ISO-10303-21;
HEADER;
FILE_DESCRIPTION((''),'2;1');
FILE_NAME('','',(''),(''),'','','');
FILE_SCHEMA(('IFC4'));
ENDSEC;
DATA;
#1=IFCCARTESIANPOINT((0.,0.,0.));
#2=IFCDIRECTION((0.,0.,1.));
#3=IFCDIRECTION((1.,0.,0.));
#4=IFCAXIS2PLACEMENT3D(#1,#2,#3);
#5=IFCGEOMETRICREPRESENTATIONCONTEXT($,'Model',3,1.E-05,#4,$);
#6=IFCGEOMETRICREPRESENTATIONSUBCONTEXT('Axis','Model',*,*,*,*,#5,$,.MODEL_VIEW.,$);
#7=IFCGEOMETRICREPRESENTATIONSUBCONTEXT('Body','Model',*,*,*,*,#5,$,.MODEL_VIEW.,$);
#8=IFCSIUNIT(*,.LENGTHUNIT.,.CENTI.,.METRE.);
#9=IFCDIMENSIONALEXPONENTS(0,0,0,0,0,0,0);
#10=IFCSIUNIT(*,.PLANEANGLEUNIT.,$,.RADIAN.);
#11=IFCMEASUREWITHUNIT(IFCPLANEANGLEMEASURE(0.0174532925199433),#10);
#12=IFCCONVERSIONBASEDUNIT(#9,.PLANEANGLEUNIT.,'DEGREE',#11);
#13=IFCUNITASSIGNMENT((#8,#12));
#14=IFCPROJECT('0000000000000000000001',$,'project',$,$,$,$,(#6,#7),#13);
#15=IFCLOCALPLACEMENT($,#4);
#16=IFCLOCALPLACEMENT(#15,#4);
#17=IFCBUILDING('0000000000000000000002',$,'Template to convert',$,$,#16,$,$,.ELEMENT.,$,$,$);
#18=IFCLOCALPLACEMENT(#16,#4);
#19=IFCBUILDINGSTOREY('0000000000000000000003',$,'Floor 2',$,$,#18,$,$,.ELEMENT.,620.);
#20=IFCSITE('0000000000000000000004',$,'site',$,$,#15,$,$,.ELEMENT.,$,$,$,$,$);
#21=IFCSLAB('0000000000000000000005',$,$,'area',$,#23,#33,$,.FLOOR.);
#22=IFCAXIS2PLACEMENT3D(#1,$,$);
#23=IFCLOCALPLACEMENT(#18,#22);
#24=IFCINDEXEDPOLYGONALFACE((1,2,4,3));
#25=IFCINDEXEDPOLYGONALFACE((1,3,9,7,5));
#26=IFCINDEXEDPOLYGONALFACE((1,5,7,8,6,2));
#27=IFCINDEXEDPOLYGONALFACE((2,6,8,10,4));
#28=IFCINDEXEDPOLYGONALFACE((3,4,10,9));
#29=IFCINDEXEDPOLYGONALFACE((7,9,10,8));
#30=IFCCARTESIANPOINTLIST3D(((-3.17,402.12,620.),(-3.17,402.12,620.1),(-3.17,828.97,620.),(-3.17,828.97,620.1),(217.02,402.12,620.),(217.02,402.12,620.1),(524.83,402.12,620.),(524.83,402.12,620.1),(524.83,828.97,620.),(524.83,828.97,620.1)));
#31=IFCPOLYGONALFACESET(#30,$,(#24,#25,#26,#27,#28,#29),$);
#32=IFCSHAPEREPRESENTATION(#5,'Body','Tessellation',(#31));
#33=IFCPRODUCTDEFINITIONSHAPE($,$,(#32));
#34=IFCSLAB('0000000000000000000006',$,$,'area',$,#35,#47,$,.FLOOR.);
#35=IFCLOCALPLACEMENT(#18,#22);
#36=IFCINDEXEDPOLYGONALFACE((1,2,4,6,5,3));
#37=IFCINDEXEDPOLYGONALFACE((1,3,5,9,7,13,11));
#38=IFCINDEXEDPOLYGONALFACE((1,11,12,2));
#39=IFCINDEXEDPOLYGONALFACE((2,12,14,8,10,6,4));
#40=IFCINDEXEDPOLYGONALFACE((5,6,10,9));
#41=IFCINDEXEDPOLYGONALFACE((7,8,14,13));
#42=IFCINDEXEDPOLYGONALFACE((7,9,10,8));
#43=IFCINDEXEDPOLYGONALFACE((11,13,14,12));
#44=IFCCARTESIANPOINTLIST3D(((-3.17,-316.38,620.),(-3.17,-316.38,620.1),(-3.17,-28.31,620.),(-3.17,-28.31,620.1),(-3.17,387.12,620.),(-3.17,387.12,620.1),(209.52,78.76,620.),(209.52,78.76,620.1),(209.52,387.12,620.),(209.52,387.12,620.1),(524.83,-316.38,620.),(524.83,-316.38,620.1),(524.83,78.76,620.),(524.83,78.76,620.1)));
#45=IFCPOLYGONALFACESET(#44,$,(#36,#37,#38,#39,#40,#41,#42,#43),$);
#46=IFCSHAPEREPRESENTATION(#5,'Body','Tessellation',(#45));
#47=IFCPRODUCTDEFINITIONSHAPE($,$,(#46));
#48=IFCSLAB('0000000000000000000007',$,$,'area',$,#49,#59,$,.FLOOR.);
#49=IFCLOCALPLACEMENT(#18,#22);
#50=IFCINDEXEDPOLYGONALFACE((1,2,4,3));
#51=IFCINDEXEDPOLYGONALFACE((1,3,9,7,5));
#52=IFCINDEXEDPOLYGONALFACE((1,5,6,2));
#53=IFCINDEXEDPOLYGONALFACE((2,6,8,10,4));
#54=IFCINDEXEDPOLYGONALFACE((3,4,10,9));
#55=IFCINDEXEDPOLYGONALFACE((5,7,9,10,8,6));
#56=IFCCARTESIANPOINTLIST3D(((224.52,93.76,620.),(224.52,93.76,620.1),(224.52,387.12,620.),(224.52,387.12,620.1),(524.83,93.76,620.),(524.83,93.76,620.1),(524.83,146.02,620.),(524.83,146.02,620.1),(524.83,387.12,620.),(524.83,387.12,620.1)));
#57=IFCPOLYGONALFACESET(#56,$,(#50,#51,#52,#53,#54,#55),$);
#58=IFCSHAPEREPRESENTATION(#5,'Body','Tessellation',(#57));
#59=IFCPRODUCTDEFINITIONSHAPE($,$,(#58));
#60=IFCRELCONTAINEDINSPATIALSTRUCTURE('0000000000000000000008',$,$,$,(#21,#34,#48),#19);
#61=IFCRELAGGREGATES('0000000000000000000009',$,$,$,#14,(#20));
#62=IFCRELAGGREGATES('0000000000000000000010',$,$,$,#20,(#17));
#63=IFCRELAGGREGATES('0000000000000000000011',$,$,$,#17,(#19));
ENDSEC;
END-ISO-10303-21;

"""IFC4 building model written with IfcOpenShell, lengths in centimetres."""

from ifc_helpers import new_model, entity, si_unit, converted_unit, frame, origin_with_axes, place, context, subcontext, project, spatial, polyline, outline, extrude, element, save


model = new_model("IFC4")

# Units and contexts
model_context = context("Model", 3, precision=1e-05, world=origin_with_axes())
body_context = subcontext(model_context, "Body", "Model", "MODEL_VIEW")
axis_context = subcontext(model_context, "Axis", "Model", "MODEL_VIEW")
ifc_project = project(units=[si_unit("LENGTHUNIT", "METRE", prefix="CENTI"), converted_unit("PLANEANGLEUNIT", "DEGREE", entity("IfcPlaneAngleMeasure", 0.0174532925199433), si_unit("PLANEANGLEUNIT", "RADIAN"), dimensions=[0, 0, 0, 0, 0, 0, 0])], contexts=[axis_context, body_context])

# Site, building, storey
site_placement = place(None, origin_with_axes())
site = spatial("IfcSite", under=ifc_project, at=site_placement, Name="site", CompositionType="ELEMENT")
building_placement = place(site_placement, origin_with_axes())
building = spatial("IfcBuilding", under=site, at=building_placement, Name="Template to convert", CompositionType="ELEMENT")
storey_placement = place(building_placement, origin_with_axes())
storey = spatial("IfcBuildingStorey", under=building, at=storey_placement, Name="Floor 2", CompositionType="ELEMENT", Elevation=620.0)

# Slabs
slab_1_placement = place(storey_placement, frame((0.0, 0.0, 620.0), z_axis=(0.0, 0.0, 1.0), x_axis=(1.0, 0.0, 0.0)))
element("IfcSlab", 1, at=slab_1_placement, inside=storey, Description="area", PredefinedType="FLOOR", context=model_context, shape_type="SweptSolid", body=[
    extrude(outline(polyline([(-3.17, 828.97, 0.0), (-3.17, 402.12, 0.0), (217.02, 402.12, 0.0), (524.83, 402.12, 0.0), (524.83, 828.97, 0.0), (-3.17, 828.97, 0.0), (-3.17, 828.97, 0.0)])), origin_with_axes(), (0.0, 0.0, 1.0), 0.1),
])
slab_2_placement = place(storey_placement, frame((0.0, 0.0, 620.0), z_axis=(0.0, 0.0, 1.0), x_axis=(1.0, 0.0, 0.0)))
element("IfcSlab", 2, at=slab_2_placement, inside=storey, Description="area", PredefinedType="FLOOR", context=model_context, shape_type="SweptSolid", body=[
    extrude(outline(polyline([(-3.17, 387.12, 0.0), (-3.17, -28.31, 0.0), (-3.17, -316.38, 0.0), (524.83, -316.38, 0.0), (524.83, 78.76, 0.0), (209.52, 78.76, 0.0), (209.52, 387.12, 0.0), (-3.17, 387.12, 0.0), (-3.17, 387.12, 0.0)])), origin_with_axes(), (0.0, 0.0, 1.0), 0.1),
])
slab_3_placement = place(storey_placement, frame((0.0, 0.0, 620.0), z_axis=(0.0, 0.0, 1.0), x_axis=(1.0, 0.0, 0.0)))
element("IfcSlab", 3, at=slab_3_placement, inside=storey, Description="area", PredefinedType="FLOOR", context=model_context, shape_type="SweptSolid", body=[
    extrude(outline(polyline([(224.52, 93.76, 0.0), (524.83, 93.76, 0.0), (524.83, 146.02, 0.0), (524.83, 387.12, 0.0), (224.52, 387.12, 0.0), (224.52, 93.76, 0.0), (224.52, 93.76, 0.0)])), origin_with_axes(), (0.0, 0.0, 1.0), 0.1),
])

save(model, "model.ifc")
